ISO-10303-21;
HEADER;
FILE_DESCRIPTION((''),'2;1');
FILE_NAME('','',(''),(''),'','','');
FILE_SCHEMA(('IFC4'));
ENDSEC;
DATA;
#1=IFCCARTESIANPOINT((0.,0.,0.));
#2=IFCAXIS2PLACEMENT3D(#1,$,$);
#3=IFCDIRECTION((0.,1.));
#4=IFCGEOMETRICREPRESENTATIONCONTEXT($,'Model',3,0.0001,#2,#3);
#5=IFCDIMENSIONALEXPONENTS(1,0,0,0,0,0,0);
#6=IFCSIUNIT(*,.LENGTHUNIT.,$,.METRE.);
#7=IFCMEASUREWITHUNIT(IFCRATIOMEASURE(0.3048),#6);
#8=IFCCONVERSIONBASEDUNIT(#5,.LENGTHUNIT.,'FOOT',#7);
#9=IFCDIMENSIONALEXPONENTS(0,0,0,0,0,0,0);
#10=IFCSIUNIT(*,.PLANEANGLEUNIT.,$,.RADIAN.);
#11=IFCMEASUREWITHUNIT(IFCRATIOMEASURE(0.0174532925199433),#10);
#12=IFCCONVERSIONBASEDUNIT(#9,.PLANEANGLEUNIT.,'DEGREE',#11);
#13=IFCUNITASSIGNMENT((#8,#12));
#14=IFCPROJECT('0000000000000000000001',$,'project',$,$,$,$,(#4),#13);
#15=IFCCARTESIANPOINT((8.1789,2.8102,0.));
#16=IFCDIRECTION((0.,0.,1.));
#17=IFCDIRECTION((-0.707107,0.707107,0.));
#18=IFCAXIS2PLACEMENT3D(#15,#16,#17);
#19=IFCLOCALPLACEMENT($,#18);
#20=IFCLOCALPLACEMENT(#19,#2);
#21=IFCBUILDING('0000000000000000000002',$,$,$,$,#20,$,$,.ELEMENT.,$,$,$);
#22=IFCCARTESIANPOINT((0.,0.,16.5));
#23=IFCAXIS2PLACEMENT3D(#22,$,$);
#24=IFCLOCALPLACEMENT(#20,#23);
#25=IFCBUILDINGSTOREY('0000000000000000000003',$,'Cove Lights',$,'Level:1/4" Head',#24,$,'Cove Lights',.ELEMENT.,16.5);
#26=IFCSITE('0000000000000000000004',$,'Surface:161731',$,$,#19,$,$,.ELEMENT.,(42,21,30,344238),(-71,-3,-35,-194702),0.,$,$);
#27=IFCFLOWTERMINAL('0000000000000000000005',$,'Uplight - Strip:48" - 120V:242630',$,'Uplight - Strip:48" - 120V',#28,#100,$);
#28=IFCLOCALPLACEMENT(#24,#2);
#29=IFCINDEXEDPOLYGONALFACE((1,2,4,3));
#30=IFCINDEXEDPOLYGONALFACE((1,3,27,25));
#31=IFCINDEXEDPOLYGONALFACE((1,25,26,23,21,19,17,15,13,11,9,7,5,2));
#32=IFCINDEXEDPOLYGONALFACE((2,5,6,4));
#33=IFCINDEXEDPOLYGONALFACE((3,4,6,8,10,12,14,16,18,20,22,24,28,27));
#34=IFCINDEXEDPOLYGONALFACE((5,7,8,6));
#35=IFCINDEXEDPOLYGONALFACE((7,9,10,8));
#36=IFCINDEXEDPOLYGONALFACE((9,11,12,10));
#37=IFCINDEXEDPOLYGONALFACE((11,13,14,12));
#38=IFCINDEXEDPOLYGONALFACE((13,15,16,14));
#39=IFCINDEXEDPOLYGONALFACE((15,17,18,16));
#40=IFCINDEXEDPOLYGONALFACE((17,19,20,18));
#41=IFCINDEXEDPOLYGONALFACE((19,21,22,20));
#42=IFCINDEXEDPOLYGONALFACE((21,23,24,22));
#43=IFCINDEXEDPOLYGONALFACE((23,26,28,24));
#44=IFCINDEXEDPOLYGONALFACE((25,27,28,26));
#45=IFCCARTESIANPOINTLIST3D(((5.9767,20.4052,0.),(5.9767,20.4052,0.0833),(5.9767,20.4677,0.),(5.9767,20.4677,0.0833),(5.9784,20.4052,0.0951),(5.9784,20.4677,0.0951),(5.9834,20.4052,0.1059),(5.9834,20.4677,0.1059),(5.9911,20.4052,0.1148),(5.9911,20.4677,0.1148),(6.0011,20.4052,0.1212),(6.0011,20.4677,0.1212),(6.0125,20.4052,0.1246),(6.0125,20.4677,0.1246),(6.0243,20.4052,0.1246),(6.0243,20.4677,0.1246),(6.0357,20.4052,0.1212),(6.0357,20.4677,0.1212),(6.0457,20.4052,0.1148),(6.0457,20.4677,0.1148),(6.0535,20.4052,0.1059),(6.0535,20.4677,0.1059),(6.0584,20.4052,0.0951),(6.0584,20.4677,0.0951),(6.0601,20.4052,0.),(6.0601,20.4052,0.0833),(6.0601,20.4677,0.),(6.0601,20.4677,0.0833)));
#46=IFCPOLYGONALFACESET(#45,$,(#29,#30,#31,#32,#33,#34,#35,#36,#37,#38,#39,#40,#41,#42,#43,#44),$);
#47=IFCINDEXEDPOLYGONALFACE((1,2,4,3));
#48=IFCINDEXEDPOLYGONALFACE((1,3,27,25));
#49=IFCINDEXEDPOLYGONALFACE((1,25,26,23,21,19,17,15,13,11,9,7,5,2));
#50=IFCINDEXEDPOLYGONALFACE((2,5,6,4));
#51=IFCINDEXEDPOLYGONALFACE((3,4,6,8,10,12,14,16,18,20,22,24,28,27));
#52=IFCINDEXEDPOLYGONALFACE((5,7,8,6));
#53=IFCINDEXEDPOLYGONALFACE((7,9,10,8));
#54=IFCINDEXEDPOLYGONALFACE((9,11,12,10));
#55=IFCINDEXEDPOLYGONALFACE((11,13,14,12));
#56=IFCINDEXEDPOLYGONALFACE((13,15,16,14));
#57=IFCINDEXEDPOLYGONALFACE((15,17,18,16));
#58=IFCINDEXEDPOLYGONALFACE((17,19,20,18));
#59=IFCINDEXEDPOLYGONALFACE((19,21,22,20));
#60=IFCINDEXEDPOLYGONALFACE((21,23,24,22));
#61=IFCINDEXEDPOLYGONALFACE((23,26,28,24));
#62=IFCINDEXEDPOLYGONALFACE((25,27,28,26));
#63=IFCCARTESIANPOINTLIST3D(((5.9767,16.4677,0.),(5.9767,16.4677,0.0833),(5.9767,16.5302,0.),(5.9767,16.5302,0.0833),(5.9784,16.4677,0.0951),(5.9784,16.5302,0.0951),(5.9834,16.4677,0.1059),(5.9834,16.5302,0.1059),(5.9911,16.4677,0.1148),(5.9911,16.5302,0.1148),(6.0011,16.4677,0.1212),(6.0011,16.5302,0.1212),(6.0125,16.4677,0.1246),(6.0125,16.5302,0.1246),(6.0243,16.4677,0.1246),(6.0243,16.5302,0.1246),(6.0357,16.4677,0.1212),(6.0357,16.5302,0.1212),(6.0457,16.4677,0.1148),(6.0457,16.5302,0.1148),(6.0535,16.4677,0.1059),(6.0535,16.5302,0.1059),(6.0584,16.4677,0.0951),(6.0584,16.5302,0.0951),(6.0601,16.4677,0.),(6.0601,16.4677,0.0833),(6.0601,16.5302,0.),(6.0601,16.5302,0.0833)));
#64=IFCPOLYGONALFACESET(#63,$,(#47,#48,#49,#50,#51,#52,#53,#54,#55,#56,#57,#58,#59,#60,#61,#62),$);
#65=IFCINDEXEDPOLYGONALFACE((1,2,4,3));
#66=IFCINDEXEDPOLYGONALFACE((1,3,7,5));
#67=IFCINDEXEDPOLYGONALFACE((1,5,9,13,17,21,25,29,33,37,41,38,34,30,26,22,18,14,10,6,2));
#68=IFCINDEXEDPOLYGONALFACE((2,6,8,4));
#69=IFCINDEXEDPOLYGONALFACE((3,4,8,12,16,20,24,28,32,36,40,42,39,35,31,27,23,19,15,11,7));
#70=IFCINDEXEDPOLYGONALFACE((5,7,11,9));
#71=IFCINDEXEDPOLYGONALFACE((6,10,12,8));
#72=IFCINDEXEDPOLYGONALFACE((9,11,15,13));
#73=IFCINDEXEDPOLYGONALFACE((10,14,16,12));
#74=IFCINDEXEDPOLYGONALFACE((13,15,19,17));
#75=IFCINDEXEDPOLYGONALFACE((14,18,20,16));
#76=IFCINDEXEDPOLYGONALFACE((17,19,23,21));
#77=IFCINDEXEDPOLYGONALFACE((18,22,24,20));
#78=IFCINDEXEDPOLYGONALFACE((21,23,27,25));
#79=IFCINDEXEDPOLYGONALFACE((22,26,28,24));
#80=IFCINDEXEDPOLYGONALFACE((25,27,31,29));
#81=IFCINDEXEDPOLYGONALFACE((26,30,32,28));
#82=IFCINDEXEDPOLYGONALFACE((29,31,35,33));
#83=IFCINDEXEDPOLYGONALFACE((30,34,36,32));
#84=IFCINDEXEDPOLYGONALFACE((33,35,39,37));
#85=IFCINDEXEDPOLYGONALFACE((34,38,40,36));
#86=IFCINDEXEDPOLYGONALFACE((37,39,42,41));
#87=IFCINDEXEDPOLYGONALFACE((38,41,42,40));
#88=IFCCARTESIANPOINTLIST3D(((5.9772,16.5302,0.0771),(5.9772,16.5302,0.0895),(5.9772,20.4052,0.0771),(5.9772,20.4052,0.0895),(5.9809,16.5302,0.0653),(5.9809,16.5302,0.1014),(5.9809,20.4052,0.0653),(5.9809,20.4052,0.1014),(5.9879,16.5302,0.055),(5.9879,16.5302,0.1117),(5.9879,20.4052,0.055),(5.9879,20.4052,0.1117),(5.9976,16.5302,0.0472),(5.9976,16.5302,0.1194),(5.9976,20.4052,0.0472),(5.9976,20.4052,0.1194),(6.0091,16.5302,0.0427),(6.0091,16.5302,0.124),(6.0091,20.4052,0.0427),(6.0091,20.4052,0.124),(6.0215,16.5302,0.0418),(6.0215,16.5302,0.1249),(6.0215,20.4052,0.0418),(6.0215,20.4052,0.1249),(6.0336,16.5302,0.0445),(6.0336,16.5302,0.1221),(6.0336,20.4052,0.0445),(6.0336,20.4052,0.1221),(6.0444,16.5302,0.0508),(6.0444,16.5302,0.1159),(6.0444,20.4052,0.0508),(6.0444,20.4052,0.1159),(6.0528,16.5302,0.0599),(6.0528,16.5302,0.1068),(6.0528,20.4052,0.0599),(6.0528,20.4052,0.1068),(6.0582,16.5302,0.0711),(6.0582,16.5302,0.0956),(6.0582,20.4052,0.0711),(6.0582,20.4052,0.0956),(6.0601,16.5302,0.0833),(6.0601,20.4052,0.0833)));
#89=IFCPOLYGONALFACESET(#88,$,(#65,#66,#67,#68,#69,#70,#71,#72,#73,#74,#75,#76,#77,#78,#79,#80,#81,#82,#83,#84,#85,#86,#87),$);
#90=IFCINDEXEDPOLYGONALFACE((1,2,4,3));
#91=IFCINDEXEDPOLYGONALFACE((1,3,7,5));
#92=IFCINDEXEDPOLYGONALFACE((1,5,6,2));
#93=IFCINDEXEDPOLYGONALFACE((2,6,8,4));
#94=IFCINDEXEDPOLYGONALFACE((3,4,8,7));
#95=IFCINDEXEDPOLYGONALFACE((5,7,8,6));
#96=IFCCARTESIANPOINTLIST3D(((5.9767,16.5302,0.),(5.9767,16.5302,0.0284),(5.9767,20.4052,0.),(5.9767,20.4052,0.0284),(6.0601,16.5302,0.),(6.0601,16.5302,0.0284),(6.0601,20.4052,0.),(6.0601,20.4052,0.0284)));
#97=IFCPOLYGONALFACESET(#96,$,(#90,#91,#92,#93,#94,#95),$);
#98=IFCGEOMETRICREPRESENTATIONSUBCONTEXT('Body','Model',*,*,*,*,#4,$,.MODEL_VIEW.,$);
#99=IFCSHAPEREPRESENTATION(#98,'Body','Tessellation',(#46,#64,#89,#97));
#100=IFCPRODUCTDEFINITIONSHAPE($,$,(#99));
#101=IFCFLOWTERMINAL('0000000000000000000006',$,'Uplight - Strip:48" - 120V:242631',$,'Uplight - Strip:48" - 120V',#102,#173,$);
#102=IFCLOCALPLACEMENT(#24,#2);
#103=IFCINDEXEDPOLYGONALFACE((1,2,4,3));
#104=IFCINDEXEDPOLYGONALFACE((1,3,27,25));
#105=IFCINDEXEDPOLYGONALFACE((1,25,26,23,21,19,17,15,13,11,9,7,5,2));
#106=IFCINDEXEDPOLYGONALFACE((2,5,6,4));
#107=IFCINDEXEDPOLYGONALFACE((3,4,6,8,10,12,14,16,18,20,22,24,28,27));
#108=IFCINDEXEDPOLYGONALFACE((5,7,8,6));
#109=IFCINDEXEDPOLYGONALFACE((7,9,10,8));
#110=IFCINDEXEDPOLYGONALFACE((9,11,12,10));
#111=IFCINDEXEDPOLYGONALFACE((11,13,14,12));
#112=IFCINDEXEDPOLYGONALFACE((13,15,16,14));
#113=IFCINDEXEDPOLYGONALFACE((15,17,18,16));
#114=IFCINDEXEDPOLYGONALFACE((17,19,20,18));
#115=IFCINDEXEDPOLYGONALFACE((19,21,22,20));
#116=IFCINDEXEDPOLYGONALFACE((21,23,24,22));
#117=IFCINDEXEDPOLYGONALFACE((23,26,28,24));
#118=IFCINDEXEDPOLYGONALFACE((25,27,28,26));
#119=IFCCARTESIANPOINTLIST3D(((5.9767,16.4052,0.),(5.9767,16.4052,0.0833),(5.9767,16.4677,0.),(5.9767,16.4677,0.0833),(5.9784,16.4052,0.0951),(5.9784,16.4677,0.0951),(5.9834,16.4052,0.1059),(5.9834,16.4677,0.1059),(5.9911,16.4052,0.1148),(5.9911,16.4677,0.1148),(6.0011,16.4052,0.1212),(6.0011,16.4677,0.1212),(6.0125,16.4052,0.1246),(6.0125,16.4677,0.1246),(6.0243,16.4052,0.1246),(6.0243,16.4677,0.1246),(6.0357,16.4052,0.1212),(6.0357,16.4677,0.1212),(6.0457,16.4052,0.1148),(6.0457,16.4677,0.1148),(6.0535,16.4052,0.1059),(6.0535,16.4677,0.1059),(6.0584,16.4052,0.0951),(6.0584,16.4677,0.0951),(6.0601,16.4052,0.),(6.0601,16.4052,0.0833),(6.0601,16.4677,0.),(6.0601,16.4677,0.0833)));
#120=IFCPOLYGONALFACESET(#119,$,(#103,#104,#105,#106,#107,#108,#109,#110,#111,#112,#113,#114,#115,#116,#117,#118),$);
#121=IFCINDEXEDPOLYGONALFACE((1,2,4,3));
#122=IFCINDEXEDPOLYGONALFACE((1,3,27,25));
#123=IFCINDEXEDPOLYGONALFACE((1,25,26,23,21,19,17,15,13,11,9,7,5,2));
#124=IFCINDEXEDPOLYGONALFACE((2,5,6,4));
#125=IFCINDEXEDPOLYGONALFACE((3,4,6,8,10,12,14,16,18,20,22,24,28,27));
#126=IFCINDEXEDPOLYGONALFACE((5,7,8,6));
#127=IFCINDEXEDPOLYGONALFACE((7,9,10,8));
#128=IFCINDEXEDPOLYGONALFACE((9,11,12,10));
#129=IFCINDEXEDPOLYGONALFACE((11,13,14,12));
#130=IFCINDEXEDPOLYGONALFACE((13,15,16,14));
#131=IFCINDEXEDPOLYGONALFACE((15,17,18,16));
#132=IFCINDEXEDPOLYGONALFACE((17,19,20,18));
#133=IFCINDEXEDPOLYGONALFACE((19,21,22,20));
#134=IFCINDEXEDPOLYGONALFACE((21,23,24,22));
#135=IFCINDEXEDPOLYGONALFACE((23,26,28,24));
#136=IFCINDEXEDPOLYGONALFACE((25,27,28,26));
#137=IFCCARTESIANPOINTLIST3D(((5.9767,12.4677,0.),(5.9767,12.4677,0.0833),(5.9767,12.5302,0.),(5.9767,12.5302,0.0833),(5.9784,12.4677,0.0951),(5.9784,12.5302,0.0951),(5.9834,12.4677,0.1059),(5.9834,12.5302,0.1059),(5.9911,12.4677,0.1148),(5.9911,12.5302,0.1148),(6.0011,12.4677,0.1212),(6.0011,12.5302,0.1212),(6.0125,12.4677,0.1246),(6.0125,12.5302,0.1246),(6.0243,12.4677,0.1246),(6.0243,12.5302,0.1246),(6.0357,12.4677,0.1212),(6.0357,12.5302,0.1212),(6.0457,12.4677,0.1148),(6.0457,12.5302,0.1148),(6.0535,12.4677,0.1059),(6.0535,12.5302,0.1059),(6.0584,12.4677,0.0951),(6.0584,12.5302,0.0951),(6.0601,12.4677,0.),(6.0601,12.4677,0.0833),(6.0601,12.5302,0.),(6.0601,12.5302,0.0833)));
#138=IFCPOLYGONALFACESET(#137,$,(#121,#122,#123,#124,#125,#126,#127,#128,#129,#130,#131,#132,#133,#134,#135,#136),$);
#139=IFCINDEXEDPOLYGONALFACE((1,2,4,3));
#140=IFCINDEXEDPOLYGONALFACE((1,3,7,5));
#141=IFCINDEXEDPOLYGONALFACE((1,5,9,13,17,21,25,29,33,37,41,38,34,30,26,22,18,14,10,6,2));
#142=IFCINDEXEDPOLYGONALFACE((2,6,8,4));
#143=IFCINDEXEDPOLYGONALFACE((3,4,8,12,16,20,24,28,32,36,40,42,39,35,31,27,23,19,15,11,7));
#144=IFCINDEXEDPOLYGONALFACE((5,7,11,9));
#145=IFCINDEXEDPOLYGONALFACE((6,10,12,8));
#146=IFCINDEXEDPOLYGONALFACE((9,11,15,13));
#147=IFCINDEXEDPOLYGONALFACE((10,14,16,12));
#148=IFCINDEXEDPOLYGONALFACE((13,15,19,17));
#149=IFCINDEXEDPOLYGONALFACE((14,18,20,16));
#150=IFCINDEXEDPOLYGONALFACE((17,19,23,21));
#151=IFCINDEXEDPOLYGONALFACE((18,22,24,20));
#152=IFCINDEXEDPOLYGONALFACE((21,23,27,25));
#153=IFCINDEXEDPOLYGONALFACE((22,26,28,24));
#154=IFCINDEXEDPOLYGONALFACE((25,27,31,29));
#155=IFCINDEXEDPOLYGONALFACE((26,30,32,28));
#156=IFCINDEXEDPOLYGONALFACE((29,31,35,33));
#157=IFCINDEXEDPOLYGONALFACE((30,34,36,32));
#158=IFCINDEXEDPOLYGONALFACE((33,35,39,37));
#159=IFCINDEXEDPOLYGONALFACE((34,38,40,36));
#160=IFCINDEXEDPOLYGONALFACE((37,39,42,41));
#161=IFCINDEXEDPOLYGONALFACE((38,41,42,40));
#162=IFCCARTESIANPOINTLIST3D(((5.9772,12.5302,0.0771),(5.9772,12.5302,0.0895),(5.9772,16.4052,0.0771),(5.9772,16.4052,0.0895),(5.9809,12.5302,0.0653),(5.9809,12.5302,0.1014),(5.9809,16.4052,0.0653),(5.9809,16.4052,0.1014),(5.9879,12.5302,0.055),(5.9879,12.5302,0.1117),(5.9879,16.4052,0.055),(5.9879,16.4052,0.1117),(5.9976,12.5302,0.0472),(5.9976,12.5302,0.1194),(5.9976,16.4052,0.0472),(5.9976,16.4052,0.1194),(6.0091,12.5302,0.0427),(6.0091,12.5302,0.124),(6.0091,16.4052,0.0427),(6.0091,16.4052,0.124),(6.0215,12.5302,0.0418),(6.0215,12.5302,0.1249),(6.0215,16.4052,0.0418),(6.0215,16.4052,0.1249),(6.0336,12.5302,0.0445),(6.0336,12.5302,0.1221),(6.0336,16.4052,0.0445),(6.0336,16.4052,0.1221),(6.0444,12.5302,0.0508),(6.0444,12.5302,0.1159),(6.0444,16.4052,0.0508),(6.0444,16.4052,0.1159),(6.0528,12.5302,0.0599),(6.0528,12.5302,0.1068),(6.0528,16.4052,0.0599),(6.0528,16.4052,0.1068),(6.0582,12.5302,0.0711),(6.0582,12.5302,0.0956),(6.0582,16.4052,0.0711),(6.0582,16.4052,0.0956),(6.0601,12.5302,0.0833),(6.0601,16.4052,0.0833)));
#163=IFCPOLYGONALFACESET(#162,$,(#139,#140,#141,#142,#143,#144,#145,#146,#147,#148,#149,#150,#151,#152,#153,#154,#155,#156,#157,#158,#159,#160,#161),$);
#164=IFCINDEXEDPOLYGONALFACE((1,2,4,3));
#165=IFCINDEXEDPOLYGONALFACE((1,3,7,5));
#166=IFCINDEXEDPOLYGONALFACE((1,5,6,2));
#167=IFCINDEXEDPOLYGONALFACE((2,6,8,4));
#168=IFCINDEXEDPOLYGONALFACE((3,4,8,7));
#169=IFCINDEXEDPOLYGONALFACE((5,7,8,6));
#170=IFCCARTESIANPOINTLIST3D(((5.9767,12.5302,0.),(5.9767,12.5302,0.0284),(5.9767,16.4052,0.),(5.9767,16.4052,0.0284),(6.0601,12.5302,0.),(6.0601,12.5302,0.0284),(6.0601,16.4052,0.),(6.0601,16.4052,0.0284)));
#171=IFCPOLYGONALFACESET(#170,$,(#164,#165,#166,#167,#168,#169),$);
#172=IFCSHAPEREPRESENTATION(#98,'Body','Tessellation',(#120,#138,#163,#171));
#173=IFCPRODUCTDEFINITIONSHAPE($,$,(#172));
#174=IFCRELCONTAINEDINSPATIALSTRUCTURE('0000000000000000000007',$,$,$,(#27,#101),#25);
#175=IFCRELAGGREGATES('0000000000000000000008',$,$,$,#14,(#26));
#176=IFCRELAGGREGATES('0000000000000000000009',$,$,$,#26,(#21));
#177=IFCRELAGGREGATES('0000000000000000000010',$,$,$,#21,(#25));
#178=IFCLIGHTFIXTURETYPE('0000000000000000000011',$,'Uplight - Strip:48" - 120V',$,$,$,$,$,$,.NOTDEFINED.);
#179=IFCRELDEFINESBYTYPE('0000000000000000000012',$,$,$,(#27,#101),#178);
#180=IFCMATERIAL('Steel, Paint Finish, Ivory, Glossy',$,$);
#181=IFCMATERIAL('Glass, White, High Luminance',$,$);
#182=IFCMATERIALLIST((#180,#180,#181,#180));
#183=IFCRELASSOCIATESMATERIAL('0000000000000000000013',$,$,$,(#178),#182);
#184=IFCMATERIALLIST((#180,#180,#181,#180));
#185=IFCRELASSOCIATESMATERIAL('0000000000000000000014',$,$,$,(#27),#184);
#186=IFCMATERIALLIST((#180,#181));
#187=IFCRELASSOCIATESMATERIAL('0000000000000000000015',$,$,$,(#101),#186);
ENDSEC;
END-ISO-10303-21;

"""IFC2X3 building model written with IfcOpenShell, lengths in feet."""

from ifc_helpers import new_model, entity, si_unit, converted_unit, direction, frame, frame_2d, origin, origin_2d_with_axis, place, context, subcontext, project, spatial, polyline, circle_curve, parameter, trimmed, segment, composite_curve, rectangle, circle, outline, extrude, source, transform, mapped, material, material_list, type_object, type_shapes, element, save


model = new_model("IFC2X3")

# Units and contexts
model_context = context("Model", 3, precision=0.0001, world=origin(), true_north=direction((0.0, 1.0)))
body_context = subcontext(model_context, "Body", "Model", "MODEL_VIEW")
ifc_project = project(units=[converted_unit("LENGTHUNIT", "FOOT", entity("IfcRatioMeasure", 0.3048), si_unit("LENGTHUNIT", "METRE"), dimensions=[1, 0, 0, 0, 0, 0, 0]), converted_unit("PLANEANGLEUNIT", "DEGREE", entity("IfcRatioMeasure", 0.0174532925199433), si_unit("PLANEANGLEUNIT", "RADIAN"), dimensions=[0, 0, 0, 0, 0, 0, 0])], contexts=[model_context])

# Site, building, storey
site_placement = place(None, frame((8.1789, 2.8102, 0.0), z_axis=(0.0, 0.0, 1.0), x_axis=(-0.707107, 0.707107, 0.0)))
site = spatial("IfcSite", under=ifc_project, at=site_placement, Name="Surface:161731", CompositionType="ELEMENT", RefLatitude=(42, 21, 30, 344238), RefLongitude=(-71, -3, -35, -194702), RefElevation=0.0)
building_placement = place(site_placement, origin())
building = spatial("IfcBuilding", under=site, at=building_placement, CompositionType="ELEMENT")
storey_placement = place(building_placement, frame((0.0, 0.0, 16.5)))
storey = spatial("IfcBuildingStorey", under=building, at=storey_placement, Name="Cove Lights", ObjectType="Level:1/4\" Head", LongName="Cove Lights", CompositionType="ELEMENT", Elevation=16.5)

# Flow terminals
ifc_material_1 = material(Name="Steel, Paint Finish, Ivory, Glossy")
ifc_material_2 = material(Name="Glass, White, High Luminance")
ifc_material_list_1 = material_list([ifc_material_1, ifc_material_1, ifc_material_2, ifc_material_1])
ifc_material_list_2 = material_list([ifc_material_1, ifc_material_1, ifc_material_2, ifc_material_1])
light_fixture_type_1 = type_object("IfcLightFixtureType", Name="Uplight - Strip:48\" - 120V", PredefinedType="NOTDEFINED", material=ifc_material_list_2)
shared_shape_1 = source(origin(), body_context, "Body", "SweptSolid", [
    extrude(outline(composite_curve([segment(polyline([(-0.0417, -0.0417), (0.0417, -0.0417)]), True, "CONTINUOUS"), segment(polyline([(0.0417, -0.0417), (0.0417, 0.0417)]), True, "CONTINUOUS"), segment(trimmed(circle_curve(frame_2d((0.0, 0.0417), x_axis=(-1.0, 0.0)), 0.0417), [parameter(180.0)], [parameter(0.0)], True, "PARAMETER"), True, "CONTINUOUS"), segment(polyline([(-0.0417, 0.0417), (-0.0417, -0.0417)]), True, "CONTINUOUS")], self_intersect=False)), frame((1.9375, 0.0, 0.0417), z_axis=(1.0, 0.0, 0.0), x_axis=(0.0, 1.0, 0.0)), (0.0, 0.0, 1.0), 0.0625),
    extrude(outline(composite_curve([segment(polyline([(-0.0417, -0.0417), (0.0417, -0.0417)]), True, "CONTINUOUS"), segment(trimmed(circle_curve(frame_2d((0.0417, 0.0), x_axis=(1.0, 0.0)), 0.0417), [parameter(270.0)], [parameter(90.0)], True, "PARAMETER"), True, "CONTINUOUS"), segment(polyline([(0.0417, 0.0417), (-0.0417, 0.0417)]), True, "CONTINUOUS"), segment(polyline([(-0.0417, 0.0417), (-0.0417, -0.0417)]), True, "CONTINUOUS")], self_intersect=False)), frame((-2.0, 0.0, 0.0417), z_axis=(1.0, 0.0, 0.0), x_axis=(0.0, 0.0, 1.0)), (0.0, 0.0, 1.0), 0.0625),
    extrude(circle(Radius=0.0417, at=frame_2d((0.0, 0.0), x_axis=(1.0, 0.0))), frame((-1.9375, 0.0, 0.0833), z_axis=(1.0, 0.0, 0.0), x_axis=(0.0, -1.0, 0.0)), (0.0, 0.0, 1.0), 3.875),
    extrude(rectangle(XDim=0.0833, YDim=3.875, at=origin_2d_with_axis()), frame((0.0, 0.0, 0.0), z_axis=(0.0, 0.0, 1.0), x_axis=(0.0, 1.0, 0.0)), (0.0, 0.0, 1.0), 0.0284),
])
type_shapes(light_fixture_type_1, [shared_shape_1])
flow_terminal_1_placement = place(storey_placement, frame((6.0184, 18.4677, 0.0), z_axis=(0.0, 0.0, 1.0), x_axis=(0.0, 1.0, 0.0)))
element("IfcFlowTerminal", 1, at=flow_terminal_1_placement, inside=storey, type_object=light_fixture_type_1, material=ifc_material_list_1, Name="Uplight - Strip:48\" - 120V:242630", ObjectType="Uplight - Strip:48\" - 120V", context=body_context, shape_type="MappedRepresentation", body=[
    mapped(shared_shape_1, transform((0.0, 0.0, 0.0), scale=1.0)),
])
ifc_material_list_3 = material_list([ifc_material_1, ifc_material_2])
flow_terminal_2_placement = place(storey_placement, frame((6.0184, 14.4677, 0.0), z_axis=(0.0, 0.0, 1.0), x_axis=(0.0, 1.0, 0.0)))
element("IfcFlowTerminal", 2, at=flow_terminal_2_placement, inside=storey, type_object=light_fixture_type_1, material=ifc_material_list_3, Name="Uplight - Strip:48\" - 120V:242631", ObjectType="Uplight - Strip:48\" - 120V", context=body_context, shape_type="MappedRepresentation", body=[
    mapped(shared_shape_1, transform((0.0, 0.0, 0.0), scale=1.0)),
])

save(model, "model.ifc")
